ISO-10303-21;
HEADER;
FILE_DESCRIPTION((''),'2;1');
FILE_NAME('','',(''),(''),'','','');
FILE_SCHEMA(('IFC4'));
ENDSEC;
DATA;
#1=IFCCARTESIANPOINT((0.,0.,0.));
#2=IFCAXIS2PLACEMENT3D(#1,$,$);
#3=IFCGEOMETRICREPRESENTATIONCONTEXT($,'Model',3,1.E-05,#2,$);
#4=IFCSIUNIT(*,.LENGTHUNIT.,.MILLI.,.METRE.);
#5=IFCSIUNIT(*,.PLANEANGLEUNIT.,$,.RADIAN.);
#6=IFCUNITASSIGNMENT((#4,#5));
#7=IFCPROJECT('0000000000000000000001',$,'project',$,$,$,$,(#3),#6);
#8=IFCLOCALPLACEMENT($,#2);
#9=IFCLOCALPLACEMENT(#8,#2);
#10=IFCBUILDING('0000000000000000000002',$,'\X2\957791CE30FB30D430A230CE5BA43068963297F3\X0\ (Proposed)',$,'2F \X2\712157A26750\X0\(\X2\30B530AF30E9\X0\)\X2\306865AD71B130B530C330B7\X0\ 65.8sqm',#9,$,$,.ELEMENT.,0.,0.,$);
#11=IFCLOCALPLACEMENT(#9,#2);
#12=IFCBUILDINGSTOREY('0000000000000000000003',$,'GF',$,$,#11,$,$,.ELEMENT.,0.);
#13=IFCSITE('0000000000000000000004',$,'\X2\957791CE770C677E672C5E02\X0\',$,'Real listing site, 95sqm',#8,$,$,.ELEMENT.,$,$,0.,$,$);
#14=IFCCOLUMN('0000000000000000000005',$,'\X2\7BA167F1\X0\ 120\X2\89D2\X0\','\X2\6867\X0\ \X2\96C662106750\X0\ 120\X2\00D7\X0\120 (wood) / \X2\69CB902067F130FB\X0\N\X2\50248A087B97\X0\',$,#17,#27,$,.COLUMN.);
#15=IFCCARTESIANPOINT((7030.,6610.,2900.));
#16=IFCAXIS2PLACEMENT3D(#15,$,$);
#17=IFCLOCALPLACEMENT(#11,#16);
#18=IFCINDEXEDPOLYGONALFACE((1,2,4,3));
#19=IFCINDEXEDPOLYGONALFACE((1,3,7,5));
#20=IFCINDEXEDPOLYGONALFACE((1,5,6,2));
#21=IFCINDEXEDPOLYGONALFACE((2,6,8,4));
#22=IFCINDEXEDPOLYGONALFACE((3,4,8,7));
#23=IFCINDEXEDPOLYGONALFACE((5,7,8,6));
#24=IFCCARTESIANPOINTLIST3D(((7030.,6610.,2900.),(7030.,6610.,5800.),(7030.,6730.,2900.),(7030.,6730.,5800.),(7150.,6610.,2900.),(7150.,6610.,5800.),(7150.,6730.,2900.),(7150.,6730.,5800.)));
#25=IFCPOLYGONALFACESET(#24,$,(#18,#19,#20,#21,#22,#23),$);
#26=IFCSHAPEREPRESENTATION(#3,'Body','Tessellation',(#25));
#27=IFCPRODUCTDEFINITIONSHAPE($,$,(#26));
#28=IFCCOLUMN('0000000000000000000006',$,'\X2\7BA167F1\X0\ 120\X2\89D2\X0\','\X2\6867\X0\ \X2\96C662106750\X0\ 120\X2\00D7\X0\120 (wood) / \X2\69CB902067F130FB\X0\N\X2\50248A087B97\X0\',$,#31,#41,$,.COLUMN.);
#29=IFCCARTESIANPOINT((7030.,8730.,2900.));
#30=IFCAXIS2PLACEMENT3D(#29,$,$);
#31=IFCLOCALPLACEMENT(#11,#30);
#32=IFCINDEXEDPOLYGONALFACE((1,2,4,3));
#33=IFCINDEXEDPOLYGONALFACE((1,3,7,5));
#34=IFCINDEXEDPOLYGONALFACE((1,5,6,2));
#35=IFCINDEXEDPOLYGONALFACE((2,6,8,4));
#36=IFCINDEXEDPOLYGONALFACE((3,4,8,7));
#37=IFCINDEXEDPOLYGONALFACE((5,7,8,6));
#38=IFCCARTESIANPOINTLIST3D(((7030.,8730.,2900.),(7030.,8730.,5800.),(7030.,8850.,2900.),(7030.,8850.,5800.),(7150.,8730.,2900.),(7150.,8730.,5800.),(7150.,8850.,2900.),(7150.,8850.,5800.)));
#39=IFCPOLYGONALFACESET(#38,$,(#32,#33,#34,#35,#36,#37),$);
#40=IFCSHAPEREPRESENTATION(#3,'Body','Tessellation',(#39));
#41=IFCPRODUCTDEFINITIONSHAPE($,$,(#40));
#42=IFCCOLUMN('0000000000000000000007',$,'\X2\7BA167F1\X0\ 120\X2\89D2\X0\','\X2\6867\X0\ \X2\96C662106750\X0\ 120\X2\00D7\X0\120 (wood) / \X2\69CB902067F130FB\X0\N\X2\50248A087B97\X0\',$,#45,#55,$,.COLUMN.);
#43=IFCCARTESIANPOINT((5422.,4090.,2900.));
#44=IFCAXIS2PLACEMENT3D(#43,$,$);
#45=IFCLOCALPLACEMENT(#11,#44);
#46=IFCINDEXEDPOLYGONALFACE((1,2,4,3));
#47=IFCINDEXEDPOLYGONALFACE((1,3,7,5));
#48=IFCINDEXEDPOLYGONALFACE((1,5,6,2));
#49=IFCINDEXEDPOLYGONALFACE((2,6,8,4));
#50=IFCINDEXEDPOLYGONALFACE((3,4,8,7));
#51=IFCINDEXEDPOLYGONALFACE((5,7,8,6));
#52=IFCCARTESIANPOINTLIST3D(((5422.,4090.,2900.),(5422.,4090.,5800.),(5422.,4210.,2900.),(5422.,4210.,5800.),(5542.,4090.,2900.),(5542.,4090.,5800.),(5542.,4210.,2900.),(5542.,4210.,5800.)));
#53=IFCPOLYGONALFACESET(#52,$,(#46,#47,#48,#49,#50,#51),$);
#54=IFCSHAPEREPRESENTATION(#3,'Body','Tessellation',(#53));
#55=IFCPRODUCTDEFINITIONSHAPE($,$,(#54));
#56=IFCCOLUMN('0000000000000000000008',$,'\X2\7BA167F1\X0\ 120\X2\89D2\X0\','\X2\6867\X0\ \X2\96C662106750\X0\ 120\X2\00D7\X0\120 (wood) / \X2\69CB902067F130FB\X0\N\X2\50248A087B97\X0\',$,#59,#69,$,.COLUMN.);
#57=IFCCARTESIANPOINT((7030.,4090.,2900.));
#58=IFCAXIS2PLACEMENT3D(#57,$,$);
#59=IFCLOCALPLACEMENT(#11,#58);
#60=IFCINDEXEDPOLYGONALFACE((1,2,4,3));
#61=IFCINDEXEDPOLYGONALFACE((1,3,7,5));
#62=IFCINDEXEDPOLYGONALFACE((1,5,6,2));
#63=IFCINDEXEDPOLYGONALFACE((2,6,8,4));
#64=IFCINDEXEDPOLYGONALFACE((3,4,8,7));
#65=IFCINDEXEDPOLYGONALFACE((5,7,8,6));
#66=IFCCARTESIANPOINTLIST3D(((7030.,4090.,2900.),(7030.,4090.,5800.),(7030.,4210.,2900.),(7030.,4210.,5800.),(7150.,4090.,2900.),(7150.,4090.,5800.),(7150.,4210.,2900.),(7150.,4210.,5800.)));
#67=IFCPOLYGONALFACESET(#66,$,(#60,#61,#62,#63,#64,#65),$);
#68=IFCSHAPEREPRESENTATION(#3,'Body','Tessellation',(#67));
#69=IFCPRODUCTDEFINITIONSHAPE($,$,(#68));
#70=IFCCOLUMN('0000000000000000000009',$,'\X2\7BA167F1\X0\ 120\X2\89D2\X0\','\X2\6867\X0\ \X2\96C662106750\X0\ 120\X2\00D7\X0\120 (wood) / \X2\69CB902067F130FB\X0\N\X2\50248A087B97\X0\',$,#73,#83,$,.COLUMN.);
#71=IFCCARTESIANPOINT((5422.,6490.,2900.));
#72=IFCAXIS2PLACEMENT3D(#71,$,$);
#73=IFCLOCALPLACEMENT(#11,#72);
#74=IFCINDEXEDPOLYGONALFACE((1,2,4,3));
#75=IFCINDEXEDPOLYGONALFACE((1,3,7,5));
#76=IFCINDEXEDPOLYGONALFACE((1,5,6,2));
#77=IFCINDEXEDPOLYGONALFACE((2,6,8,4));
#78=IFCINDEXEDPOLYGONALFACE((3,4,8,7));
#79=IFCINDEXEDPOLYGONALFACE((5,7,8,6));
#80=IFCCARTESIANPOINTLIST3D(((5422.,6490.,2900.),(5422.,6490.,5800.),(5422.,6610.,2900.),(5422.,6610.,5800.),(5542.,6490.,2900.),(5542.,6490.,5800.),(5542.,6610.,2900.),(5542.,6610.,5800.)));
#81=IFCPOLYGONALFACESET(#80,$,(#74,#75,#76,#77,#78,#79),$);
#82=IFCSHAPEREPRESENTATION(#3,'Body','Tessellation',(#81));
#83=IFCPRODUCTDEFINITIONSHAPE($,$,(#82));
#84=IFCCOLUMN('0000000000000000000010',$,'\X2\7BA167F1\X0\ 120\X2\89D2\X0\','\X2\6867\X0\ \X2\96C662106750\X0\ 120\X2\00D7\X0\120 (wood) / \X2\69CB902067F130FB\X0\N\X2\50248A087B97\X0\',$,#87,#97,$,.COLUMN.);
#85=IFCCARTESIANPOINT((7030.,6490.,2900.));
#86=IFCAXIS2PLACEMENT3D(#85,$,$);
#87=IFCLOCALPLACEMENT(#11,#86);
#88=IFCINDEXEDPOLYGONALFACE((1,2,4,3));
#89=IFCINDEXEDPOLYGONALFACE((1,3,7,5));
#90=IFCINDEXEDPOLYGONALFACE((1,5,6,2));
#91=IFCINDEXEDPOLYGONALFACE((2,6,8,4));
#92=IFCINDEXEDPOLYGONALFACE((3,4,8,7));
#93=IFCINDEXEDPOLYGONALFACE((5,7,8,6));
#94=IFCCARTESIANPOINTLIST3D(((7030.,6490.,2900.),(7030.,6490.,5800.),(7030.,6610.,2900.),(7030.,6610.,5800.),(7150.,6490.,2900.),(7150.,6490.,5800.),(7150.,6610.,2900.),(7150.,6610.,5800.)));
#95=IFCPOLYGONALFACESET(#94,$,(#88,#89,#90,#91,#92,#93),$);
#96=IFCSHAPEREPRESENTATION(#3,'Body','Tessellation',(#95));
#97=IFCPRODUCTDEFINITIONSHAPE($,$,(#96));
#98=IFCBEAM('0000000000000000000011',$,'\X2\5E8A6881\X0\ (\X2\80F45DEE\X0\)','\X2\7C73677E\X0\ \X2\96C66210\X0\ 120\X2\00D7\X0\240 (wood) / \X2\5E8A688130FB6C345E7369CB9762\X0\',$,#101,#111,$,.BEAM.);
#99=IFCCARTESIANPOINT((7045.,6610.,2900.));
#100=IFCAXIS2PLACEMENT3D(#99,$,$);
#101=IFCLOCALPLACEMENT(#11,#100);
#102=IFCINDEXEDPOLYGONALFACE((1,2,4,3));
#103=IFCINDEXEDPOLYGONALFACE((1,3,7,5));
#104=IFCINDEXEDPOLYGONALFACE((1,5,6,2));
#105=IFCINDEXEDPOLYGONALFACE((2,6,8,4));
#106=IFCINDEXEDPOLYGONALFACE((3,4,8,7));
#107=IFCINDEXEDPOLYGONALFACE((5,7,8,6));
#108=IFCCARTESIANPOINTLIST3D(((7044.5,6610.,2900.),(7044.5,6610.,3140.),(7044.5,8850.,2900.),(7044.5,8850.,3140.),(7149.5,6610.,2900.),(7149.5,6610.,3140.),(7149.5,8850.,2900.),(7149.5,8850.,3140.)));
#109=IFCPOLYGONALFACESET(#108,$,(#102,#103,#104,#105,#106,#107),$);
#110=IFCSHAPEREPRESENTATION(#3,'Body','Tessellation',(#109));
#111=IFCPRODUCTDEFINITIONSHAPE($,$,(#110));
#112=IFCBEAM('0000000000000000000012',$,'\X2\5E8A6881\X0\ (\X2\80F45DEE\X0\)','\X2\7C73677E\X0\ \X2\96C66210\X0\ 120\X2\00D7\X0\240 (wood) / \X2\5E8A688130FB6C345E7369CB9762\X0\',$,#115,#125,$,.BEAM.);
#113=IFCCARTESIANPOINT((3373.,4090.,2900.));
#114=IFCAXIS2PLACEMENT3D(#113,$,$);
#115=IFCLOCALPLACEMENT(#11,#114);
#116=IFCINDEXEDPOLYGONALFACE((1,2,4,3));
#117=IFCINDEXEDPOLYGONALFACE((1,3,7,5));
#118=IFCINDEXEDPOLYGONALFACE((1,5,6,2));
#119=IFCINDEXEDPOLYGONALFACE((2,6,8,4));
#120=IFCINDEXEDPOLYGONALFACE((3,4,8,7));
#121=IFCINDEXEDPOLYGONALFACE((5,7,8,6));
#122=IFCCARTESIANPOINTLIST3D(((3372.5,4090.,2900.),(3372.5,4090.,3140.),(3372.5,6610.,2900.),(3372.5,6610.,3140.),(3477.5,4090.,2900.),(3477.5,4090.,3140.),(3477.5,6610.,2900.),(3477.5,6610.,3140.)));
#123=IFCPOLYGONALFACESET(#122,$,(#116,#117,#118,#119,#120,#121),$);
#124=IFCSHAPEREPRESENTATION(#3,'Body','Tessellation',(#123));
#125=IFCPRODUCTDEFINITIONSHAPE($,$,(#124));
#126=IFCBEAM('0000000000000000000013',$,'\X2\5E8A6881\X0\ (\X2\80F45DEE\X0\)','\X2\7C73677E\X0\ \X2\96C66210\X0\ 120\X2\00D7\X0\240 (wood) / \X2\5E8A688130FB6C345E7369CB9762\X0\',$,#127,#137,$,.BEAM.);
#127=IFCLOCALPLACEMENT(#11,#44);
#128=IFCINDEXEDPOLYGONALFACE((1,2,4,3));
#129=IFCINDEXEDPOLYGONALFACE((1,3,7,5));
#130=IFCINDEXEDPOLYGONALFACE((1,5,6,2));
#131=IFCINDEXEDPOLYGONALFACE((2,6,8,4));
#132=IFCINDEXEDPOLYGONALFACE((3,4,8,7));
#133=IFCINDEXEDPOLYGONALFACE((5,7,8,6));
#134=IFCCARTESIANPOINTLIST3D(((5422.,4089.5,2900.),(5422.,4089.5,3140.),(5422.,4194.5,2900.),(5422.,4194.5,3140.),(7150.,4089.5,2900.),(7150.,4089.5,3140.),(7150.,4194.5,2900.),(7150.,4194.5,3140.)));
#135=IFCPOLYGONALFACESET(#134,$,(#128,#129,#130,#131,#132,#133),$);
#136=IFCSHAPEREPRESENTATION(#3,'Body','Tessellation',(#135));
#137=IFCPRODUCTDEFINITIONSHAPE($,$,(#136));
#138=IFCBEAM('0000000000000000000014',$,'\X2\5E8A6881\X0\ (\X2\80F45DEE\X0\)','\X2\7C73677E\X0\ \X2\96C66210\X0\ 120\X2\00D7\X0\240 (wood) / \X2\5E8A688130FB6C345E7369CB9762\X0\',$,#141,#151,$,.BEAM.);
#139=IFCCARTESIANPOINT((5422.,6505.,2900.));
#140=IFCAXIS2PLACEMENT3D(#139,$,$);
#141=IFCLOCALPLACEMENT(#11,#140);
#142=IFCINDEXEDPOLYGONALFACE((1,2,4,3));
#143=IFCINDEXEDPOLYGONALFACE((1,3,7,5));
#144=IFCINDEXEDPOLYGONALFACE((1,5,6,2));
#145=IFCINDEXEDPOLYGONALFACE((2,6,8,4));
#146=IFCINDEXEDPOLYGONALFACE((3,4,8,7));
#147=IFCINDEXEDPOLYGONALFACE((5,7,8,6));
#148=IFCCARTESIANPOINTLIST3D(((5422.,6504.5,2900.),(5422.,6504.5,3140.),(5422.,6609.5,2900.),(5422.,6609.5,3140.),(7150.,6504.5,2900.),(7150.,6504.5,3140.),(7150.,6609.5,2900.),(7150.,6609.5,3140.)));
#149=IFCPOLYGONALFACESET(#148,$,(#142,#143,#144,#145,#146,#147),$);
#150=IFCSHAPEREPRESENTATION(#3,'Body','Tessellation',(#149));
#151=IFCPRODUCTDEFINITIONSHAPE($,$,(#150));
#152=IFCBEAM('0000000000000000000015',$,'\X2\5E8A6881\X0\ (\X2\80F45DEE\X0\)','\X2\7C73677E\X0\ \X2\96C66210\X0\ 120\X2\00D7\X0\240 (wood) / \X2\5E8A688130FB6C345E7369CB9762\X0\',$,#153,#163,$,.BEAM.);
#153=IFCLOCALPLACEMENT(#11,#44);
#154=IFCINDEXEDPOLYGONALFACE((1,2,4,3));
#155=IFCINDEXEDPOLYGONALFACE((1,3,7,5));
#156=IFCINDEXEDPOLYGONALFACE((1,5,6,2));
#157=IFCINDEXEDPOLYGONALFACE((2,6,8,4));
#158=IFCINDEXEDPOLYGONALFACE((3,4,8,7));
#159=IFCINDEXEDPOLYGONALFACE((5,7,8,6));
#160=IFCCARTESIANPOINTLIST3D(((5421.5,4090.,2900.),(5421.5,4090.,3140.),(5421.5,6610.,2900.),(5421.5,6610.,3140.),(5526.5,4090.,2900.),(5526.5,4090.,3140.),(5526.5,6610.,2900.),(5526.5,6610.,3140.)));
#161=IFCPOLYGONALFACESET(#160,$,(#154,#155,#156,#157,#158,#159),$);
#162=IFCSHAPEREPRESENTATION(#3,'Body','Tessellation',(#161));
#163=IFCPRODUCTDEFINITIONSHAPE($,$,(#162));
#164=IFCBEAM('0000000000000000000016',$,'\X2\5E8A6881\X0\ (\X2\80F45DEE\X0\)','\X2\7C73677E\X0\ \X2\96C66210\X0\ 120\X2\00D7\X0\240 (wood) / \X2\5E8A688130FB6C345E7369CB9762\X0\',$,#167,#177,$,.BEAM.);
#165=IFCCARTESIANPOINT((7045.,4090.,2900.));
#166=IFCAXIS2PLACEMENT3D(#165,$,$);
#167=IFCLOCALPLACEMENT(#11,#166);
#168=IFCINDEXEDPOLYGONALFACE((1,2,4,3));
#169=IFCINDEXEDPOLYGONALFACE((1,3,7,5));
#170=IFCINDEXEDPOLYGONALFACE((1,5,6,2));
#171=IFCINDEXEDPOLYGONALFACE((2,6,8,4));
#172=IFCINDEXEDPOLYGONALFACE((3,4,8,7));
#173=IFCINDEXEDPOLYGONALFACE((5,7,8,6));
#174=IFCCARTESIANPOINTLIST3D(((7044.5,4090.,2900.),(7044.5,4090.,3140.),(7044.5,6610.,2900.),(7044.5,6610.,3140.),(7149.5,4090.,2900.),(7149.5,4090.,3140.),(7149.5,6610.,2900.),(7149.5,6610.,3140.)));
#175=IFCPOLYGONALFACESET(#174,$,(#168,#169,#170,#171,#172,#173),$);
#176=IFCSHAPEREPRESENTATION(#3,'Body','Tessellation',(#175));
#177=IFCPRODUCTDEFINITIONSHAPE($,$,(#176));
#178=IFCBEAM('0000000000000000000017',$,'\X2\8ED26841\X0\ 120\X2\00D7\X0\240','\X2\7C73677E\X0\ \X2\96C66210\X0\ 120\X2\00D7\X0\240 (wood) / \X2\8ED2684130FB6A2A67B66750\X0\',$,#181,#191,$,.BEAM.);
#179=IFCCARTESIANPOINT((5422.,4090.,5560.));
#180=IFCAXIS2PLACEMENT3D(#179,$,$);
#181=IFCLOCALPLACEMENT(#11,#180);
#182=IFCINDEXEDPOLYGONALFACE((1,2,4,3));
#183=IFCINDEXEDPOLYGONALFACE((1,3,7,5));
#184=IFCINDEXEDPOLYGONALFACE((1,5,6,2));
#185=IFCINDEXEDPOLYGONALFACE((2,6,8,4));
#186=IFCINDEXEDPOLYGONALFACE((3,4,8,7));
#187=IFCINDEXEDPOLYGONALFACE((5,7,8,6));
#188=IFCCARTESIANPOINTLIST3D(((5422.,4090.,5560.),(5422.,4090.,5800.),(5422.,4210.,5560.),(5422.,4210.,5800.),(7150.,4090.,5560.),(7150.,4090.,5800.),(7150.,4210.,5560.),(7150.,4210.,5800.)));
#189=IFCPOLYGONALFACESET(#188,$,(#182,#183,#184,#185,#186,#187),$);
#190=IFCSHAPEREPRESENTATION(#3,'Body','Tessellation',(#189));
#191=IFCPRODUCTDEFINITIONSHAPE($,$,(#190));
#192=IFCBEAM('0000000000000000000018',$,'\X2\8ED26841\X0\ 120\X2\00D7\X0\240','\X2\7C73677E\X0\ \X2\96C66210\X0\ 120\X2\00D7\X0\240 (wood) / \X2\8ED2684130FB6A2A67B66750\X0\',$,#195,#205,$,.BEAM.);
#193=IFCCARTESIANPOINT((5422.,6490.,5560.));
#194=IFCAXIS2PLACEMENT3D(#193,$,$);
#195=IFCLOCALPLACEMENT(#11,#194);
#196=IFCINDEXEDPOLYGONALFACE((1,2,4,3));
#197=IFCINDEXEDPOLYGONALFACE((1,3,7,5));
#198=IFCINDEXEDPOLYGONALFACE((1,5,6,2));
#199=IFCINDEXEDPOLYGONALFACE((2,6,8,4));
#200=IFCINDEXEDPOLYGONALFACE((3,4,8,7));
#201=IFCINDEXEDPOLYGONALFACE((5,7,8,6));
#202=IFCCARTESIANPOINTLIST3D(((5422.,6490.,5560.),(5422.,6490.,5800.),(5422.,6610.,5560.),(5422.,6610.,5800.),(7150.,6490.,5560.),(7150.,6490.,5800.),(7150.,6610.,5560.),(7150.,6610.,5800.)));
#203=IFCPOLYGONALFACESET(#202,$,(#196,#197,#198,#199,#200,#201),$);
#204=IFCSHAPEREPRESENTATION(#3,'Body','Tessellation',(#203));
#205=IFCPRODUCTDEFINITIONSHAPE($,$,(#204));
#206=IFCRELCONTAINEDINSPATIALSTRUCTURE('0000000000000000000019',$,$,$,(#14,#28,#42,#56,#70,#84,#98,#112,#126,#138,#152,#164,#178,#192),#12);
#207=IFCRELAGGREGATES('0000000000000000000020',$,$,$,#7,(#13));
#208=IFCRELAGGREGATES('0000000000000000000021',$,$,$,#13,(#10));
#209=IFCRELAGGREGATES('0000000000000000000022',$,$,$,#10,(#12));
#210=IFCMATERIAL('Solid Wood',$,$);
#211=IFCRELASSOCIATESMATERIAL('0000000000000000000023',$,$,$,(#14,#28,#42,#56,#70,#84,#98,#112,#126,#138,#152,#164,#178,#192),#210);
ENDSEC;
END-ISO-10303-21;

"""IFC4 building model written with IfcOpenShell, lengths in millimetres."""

from ifc_helpers import new_model, si_unit, frame, frame_2d, origin, place, context, project, spatial, rectangle, extrude, material, element, save


model = new_model("IFC4")

# Units and contexts
model_context = context("Model", 3, precision=1e-05, world=origin())
ifc_project = project(units=[si_unit("LENGTHUNIT", "METRE", prefix="MILLI"), si_unit("PLANEANGLEUNIT", "RADIAN")], contexts=[model_context])

# Site, building, storey
site_placement = place(None, origin())
site = spatial("IfcSite", under=ifc_project, at=site_placement, Name="長野県松本市", ObjectType="Real listing site, 95sqm", CompositionType="ELEMENT", RefElevation=0.0)
building_placement = place(site_placement, origin())
building = spatial("IfcBuilding", under=site, at=building_placement, Name="長野・ピアノ室と防音 (Proposed)", ObjectType="2F 無垢材(サクラ)と断熱サッシ 65.8sqm", CompositionType="ELEMENT", ElevationOfRefHeight=0.0, ElevationOfTerrain=0.0)
storey_placement = place(building_placement, origin())
storey = spatial("IfcBuildingStorey", under=building, at=storey_placement, Name="GF", CompositionType="ELEMENT", Elevation=0.0)

# Columns
ifc_material_1 = material(Name="Solid Wood")
column_1_placement = place(storey_placement, frame((7030.0, 6610.0, 2900.0)))
element("IfcColumn", 1, at=column_1_placement, inside=storey, material=ifc_material_1, Name="管柱 120角", Description="桧 集成材 120×120 (wood) / 構造柱・N値計算", PredefinedType="COLUMN", context=model_context, shape_type="SweptSolid", body=[
    extrude(rectangle(XDim=120.0, YDim=120.0, at=frame_2d((60.0, 60.0))), frame((7030.0, 6610.0, 2900.0)), (0.0, 0.0, 1.0), 2900.0),
])
column_2_placement = place(storey_placement, frame((7030.0, 8730.0, 2900.0)))
element("IfcColumn", 2, at=column_2_placement, inside=storey, material=ifc_material_1, Name="管柱 120角", Description="桧 集成材 120×120 (wood) / 構造柱・N値計算", PredefinedType="COLUMN", context=model_context, shape_type="SweptSolid", body=[
    extrude(rectangle(XDim=120.0, YDim=120.0, at=frame_2d((60.0, 60.0))), frame((7030.0, 8730.0, 2900.0)), (0.0, 0.0, 1.0), 2900.0),
])
column_3_placement = place(storey_placement, frame((5422.0, 4090.0, 2900.0)))
element("IfcColumn", 3, at=column_3_placement, inside=storey, material=ifc_material_1, Name="管柱 120角", Description="桧 集成材 120×120 (wood) / 構造柱・N値計算", PredefinedType="COLUMN", context=model_context, shape_type="SweptSolid", body=[
    extrude(rectangle(XDim=120.0, YDim=120.0, at=frame_2d((60.0, 60.0))), frame((5422.0, 4090.0, 2900.0)), (0.0, 0.0, 1.0), 2900.0),
])
column_4_placement = place(storey_placement, frame((7030.0, 4090.0, 2900.0)))
element("IfcColumn", 4, at=column_4_placement, inside=storey, material=ifc_material_1, Name="管柱 120角", Description="桧 集成材 120×120 (wood) / 構造柱・N値計算", PredefinedType="COLUMN", context=model_context, shape_type="SweptSolid", body=[
    extrude(rectangle(XDim=120.0, YDim=120.0, at=frame_2d((60.0, 60.0))), frame((7030.0, 4090.0, 2900.0)), (0.0, 0.0, 1.0), 2900.0),
])
column_5_placement = place(storey_placement, frame((5422.0, 6490.0, 2900.0)))
element("IfcColumn", 5, at=column_5_placement, inside=storey, material=ifc_material_1, Name="管柱 120角", Description="桧 集成材 120×120 (wood) / 構造柱・N値計算", PredefinedType="COLUMN", context=model_context, shape_type="SweptSolid", body=[
    extrude(rectangle(XDim=120.0, YDim=120.0, at=frame_2d((60.0, 60.0))), frame((5422.0, 6490.0, 2900.0)), (0.0, 0.0, 1.0), 2900.0),
])
column_6_placement = place(storey_placement, frame((7030.0, 6490.0, 2900.0)))
element("IfcColumn", 6, at=column_6_placement, inside=storey, material=ifc_material_1, Name="管柱 120角", Description="桧 集成材 120×120 (wood) / 構造柱・N値計算", PredefinedType="COLUMN", context=model_context, shape_type="SweptSolid", body=[
    extrude(rectangle(XDim=120.0, YDim=120.0, at=frame_2d((60.0, 60.0))), frame((7030.0, 6490.0, 2900.0)), (0.0, 0.0, 1.0), 2900.0),
])

# Beams
beam_1_placement = place(storey_placement, frame((7045.0, 6610.0, 2900.0)))
element("IfcBeam", 7, at=beam_1_placement, inside=storey, material=ifc_material_1, Name="床梁 (胴差)", Description="米松 集成 120×240 (wood) / 床梁・水平構面", PredefinedType="BEAM", context=model_context, shape_type="SweptSolid", body=[
    extrude(rectangle(XDim=105.0, YDim=2240.0, at=frame_2d((52.0, 1120.0))), frame((7045.0, 6610.0, 2900.0)), (0.0, 0.0, 1.0), 240.0),
])
beam_2_placement = place(storey_placement, frame((3373.0, 4090.0, 2900.0)))
element("IfcBeam", 8, at=beam_2_placement, inside=storey, material=ifc_material_1, Name="床梁 (胴差)", Description="米松 集成 120×240 (wood) / 床梁・水平構面", PredefinedType="BEAM", context=model_context, shape_type="SweptSolid", body=[
    extrude(rectangle(XDim=105.0, YDim=2520.0, at=frame_2d((52.0, 1260.0))), frame((3373.0, 4090.0, 2900.0)), (0.0, 0.0, 1.0), 240.0),
])
beam_3_placement = place(storey_placement, frame((5422.0, 4090.0, 2900.0)))
element("IfcBeam", 9, at=beam_3_placement, inside=storey, material=ifc_material_1, Name="床梁 (胴差)", Description="米松 集成 120×240 (wood) / 床梁・水平構面", PredefinedType="BEAM", context=model_context, shape_type="SweptSolid", body=[
    extrude(rectangle(XDim=1728.0, YDim=105.0, at=frame_2d((864.0, 52.0))), frame((5422.0, 4090.0, 2900.0)), (0.0, 0.0, 1.0), 240.0),
])
beam_4_placement = place(storey_placement, frame((5422.0, 6505.0, 2900.0)))
element("IfcBeam", 10, at=beam_4_placement, inside=storey, material=ifc_material_1, Name="床梁 (胴差)", Description="米松 集成 120×240 (wood) / 床梁・水平構面", PredefinedType="BEAM", context=model_context, shape_type="SweptSolid", body=[
    extrude(rectangle(XDim=1728.0, YDim=105.0, at=frame_2d((864.0, 52.0))), frame((5422.0, 6505.0, 2900.0)), (0.0, 0.0, 1.0), 240.0),
])
beam_5_placement = place(storey_placement, frame((5422.0, 4090.0, 2900.0)))
element("IfcBeam", 11, at=beam_5_placement, inside=storey, material=ifc_material_1, Name="床梁 (胴差)", Description="米松 集成 120×240 (wood) / 床梁・水平構面", PredefinedType="BEAM", context=model_context, shape_type="SweptSolid", body=[
    extrude(rectangle(XDim=105.0, YDim=2520.0, at=frame_2d((52.0, 1260.0))), frame((5422.0, 4090.0, 2900.0)), (0.0, 0.0, 1.0), 240.0),
])
beam_6_placement = place(storey_placement, frame((7045.0, 4090.0, 2900.0)))
element("IfcBeam", 12, at=beam_6_placement, inside=storey, material=ifc_material_1, Name="床梁 (胴差)", Description="米松 集成 120×240 (wood) / 床梁・水平構面", PredefinedType="BEAM", context=model_context, shape_type="SweptSolid", body=[
    extrude(rectangle(XDim=105.0, YDim=2520.0, at=frame_2d((52.0, 1260.0))), frame((7045.0, 4090.0, 2900.0)), (0.0, 0.0, 1.0), 240.0),
])
beam_7_placement = place(storey_placement, frame((5422.0, 4090.0, 5560.0)))
element("IfcBeam", 13, at=beam_7_placement, inside=storey, material=ifc_material_1, Name="軒桁 120×240", Description="米松 集成 120×240 (wood) / 軒桁・横架材", PredefinedType="BEAM", context=model_context, shape_type="SweptSolid", body=[
    extrude(rectangle(XDim=1728.0, YDim=120.0, at=frame_2d((864.0, 60.0))), frame((5422.0, 4090.0, 5560.0)), (0.0, 0.0, 1.0), 240.0),
])
beam_8_placement = place(storey_placement, frame((5422.0, 6490.0, 5560.0)))
element("IfcBeam", 14, at=beam_8_placement, inside=storey, material=ifc_material_1, Name="軒桁 120×240", Description="米松 集成 120×240 (wood) / 軒桁・横架材", PredefinedType="BEAM", context=model_context, shape_type="SweptSolid", body=[
    extrude(rectangle(XDim=1728.0, YDim=120.0, at=frame_2d((864.0, 60.0))), frame((5422.0, 6490.0, 5560.0)), (0.0, 0.0, 1.0), 240.0),
])

save(model, "model.ifc")
